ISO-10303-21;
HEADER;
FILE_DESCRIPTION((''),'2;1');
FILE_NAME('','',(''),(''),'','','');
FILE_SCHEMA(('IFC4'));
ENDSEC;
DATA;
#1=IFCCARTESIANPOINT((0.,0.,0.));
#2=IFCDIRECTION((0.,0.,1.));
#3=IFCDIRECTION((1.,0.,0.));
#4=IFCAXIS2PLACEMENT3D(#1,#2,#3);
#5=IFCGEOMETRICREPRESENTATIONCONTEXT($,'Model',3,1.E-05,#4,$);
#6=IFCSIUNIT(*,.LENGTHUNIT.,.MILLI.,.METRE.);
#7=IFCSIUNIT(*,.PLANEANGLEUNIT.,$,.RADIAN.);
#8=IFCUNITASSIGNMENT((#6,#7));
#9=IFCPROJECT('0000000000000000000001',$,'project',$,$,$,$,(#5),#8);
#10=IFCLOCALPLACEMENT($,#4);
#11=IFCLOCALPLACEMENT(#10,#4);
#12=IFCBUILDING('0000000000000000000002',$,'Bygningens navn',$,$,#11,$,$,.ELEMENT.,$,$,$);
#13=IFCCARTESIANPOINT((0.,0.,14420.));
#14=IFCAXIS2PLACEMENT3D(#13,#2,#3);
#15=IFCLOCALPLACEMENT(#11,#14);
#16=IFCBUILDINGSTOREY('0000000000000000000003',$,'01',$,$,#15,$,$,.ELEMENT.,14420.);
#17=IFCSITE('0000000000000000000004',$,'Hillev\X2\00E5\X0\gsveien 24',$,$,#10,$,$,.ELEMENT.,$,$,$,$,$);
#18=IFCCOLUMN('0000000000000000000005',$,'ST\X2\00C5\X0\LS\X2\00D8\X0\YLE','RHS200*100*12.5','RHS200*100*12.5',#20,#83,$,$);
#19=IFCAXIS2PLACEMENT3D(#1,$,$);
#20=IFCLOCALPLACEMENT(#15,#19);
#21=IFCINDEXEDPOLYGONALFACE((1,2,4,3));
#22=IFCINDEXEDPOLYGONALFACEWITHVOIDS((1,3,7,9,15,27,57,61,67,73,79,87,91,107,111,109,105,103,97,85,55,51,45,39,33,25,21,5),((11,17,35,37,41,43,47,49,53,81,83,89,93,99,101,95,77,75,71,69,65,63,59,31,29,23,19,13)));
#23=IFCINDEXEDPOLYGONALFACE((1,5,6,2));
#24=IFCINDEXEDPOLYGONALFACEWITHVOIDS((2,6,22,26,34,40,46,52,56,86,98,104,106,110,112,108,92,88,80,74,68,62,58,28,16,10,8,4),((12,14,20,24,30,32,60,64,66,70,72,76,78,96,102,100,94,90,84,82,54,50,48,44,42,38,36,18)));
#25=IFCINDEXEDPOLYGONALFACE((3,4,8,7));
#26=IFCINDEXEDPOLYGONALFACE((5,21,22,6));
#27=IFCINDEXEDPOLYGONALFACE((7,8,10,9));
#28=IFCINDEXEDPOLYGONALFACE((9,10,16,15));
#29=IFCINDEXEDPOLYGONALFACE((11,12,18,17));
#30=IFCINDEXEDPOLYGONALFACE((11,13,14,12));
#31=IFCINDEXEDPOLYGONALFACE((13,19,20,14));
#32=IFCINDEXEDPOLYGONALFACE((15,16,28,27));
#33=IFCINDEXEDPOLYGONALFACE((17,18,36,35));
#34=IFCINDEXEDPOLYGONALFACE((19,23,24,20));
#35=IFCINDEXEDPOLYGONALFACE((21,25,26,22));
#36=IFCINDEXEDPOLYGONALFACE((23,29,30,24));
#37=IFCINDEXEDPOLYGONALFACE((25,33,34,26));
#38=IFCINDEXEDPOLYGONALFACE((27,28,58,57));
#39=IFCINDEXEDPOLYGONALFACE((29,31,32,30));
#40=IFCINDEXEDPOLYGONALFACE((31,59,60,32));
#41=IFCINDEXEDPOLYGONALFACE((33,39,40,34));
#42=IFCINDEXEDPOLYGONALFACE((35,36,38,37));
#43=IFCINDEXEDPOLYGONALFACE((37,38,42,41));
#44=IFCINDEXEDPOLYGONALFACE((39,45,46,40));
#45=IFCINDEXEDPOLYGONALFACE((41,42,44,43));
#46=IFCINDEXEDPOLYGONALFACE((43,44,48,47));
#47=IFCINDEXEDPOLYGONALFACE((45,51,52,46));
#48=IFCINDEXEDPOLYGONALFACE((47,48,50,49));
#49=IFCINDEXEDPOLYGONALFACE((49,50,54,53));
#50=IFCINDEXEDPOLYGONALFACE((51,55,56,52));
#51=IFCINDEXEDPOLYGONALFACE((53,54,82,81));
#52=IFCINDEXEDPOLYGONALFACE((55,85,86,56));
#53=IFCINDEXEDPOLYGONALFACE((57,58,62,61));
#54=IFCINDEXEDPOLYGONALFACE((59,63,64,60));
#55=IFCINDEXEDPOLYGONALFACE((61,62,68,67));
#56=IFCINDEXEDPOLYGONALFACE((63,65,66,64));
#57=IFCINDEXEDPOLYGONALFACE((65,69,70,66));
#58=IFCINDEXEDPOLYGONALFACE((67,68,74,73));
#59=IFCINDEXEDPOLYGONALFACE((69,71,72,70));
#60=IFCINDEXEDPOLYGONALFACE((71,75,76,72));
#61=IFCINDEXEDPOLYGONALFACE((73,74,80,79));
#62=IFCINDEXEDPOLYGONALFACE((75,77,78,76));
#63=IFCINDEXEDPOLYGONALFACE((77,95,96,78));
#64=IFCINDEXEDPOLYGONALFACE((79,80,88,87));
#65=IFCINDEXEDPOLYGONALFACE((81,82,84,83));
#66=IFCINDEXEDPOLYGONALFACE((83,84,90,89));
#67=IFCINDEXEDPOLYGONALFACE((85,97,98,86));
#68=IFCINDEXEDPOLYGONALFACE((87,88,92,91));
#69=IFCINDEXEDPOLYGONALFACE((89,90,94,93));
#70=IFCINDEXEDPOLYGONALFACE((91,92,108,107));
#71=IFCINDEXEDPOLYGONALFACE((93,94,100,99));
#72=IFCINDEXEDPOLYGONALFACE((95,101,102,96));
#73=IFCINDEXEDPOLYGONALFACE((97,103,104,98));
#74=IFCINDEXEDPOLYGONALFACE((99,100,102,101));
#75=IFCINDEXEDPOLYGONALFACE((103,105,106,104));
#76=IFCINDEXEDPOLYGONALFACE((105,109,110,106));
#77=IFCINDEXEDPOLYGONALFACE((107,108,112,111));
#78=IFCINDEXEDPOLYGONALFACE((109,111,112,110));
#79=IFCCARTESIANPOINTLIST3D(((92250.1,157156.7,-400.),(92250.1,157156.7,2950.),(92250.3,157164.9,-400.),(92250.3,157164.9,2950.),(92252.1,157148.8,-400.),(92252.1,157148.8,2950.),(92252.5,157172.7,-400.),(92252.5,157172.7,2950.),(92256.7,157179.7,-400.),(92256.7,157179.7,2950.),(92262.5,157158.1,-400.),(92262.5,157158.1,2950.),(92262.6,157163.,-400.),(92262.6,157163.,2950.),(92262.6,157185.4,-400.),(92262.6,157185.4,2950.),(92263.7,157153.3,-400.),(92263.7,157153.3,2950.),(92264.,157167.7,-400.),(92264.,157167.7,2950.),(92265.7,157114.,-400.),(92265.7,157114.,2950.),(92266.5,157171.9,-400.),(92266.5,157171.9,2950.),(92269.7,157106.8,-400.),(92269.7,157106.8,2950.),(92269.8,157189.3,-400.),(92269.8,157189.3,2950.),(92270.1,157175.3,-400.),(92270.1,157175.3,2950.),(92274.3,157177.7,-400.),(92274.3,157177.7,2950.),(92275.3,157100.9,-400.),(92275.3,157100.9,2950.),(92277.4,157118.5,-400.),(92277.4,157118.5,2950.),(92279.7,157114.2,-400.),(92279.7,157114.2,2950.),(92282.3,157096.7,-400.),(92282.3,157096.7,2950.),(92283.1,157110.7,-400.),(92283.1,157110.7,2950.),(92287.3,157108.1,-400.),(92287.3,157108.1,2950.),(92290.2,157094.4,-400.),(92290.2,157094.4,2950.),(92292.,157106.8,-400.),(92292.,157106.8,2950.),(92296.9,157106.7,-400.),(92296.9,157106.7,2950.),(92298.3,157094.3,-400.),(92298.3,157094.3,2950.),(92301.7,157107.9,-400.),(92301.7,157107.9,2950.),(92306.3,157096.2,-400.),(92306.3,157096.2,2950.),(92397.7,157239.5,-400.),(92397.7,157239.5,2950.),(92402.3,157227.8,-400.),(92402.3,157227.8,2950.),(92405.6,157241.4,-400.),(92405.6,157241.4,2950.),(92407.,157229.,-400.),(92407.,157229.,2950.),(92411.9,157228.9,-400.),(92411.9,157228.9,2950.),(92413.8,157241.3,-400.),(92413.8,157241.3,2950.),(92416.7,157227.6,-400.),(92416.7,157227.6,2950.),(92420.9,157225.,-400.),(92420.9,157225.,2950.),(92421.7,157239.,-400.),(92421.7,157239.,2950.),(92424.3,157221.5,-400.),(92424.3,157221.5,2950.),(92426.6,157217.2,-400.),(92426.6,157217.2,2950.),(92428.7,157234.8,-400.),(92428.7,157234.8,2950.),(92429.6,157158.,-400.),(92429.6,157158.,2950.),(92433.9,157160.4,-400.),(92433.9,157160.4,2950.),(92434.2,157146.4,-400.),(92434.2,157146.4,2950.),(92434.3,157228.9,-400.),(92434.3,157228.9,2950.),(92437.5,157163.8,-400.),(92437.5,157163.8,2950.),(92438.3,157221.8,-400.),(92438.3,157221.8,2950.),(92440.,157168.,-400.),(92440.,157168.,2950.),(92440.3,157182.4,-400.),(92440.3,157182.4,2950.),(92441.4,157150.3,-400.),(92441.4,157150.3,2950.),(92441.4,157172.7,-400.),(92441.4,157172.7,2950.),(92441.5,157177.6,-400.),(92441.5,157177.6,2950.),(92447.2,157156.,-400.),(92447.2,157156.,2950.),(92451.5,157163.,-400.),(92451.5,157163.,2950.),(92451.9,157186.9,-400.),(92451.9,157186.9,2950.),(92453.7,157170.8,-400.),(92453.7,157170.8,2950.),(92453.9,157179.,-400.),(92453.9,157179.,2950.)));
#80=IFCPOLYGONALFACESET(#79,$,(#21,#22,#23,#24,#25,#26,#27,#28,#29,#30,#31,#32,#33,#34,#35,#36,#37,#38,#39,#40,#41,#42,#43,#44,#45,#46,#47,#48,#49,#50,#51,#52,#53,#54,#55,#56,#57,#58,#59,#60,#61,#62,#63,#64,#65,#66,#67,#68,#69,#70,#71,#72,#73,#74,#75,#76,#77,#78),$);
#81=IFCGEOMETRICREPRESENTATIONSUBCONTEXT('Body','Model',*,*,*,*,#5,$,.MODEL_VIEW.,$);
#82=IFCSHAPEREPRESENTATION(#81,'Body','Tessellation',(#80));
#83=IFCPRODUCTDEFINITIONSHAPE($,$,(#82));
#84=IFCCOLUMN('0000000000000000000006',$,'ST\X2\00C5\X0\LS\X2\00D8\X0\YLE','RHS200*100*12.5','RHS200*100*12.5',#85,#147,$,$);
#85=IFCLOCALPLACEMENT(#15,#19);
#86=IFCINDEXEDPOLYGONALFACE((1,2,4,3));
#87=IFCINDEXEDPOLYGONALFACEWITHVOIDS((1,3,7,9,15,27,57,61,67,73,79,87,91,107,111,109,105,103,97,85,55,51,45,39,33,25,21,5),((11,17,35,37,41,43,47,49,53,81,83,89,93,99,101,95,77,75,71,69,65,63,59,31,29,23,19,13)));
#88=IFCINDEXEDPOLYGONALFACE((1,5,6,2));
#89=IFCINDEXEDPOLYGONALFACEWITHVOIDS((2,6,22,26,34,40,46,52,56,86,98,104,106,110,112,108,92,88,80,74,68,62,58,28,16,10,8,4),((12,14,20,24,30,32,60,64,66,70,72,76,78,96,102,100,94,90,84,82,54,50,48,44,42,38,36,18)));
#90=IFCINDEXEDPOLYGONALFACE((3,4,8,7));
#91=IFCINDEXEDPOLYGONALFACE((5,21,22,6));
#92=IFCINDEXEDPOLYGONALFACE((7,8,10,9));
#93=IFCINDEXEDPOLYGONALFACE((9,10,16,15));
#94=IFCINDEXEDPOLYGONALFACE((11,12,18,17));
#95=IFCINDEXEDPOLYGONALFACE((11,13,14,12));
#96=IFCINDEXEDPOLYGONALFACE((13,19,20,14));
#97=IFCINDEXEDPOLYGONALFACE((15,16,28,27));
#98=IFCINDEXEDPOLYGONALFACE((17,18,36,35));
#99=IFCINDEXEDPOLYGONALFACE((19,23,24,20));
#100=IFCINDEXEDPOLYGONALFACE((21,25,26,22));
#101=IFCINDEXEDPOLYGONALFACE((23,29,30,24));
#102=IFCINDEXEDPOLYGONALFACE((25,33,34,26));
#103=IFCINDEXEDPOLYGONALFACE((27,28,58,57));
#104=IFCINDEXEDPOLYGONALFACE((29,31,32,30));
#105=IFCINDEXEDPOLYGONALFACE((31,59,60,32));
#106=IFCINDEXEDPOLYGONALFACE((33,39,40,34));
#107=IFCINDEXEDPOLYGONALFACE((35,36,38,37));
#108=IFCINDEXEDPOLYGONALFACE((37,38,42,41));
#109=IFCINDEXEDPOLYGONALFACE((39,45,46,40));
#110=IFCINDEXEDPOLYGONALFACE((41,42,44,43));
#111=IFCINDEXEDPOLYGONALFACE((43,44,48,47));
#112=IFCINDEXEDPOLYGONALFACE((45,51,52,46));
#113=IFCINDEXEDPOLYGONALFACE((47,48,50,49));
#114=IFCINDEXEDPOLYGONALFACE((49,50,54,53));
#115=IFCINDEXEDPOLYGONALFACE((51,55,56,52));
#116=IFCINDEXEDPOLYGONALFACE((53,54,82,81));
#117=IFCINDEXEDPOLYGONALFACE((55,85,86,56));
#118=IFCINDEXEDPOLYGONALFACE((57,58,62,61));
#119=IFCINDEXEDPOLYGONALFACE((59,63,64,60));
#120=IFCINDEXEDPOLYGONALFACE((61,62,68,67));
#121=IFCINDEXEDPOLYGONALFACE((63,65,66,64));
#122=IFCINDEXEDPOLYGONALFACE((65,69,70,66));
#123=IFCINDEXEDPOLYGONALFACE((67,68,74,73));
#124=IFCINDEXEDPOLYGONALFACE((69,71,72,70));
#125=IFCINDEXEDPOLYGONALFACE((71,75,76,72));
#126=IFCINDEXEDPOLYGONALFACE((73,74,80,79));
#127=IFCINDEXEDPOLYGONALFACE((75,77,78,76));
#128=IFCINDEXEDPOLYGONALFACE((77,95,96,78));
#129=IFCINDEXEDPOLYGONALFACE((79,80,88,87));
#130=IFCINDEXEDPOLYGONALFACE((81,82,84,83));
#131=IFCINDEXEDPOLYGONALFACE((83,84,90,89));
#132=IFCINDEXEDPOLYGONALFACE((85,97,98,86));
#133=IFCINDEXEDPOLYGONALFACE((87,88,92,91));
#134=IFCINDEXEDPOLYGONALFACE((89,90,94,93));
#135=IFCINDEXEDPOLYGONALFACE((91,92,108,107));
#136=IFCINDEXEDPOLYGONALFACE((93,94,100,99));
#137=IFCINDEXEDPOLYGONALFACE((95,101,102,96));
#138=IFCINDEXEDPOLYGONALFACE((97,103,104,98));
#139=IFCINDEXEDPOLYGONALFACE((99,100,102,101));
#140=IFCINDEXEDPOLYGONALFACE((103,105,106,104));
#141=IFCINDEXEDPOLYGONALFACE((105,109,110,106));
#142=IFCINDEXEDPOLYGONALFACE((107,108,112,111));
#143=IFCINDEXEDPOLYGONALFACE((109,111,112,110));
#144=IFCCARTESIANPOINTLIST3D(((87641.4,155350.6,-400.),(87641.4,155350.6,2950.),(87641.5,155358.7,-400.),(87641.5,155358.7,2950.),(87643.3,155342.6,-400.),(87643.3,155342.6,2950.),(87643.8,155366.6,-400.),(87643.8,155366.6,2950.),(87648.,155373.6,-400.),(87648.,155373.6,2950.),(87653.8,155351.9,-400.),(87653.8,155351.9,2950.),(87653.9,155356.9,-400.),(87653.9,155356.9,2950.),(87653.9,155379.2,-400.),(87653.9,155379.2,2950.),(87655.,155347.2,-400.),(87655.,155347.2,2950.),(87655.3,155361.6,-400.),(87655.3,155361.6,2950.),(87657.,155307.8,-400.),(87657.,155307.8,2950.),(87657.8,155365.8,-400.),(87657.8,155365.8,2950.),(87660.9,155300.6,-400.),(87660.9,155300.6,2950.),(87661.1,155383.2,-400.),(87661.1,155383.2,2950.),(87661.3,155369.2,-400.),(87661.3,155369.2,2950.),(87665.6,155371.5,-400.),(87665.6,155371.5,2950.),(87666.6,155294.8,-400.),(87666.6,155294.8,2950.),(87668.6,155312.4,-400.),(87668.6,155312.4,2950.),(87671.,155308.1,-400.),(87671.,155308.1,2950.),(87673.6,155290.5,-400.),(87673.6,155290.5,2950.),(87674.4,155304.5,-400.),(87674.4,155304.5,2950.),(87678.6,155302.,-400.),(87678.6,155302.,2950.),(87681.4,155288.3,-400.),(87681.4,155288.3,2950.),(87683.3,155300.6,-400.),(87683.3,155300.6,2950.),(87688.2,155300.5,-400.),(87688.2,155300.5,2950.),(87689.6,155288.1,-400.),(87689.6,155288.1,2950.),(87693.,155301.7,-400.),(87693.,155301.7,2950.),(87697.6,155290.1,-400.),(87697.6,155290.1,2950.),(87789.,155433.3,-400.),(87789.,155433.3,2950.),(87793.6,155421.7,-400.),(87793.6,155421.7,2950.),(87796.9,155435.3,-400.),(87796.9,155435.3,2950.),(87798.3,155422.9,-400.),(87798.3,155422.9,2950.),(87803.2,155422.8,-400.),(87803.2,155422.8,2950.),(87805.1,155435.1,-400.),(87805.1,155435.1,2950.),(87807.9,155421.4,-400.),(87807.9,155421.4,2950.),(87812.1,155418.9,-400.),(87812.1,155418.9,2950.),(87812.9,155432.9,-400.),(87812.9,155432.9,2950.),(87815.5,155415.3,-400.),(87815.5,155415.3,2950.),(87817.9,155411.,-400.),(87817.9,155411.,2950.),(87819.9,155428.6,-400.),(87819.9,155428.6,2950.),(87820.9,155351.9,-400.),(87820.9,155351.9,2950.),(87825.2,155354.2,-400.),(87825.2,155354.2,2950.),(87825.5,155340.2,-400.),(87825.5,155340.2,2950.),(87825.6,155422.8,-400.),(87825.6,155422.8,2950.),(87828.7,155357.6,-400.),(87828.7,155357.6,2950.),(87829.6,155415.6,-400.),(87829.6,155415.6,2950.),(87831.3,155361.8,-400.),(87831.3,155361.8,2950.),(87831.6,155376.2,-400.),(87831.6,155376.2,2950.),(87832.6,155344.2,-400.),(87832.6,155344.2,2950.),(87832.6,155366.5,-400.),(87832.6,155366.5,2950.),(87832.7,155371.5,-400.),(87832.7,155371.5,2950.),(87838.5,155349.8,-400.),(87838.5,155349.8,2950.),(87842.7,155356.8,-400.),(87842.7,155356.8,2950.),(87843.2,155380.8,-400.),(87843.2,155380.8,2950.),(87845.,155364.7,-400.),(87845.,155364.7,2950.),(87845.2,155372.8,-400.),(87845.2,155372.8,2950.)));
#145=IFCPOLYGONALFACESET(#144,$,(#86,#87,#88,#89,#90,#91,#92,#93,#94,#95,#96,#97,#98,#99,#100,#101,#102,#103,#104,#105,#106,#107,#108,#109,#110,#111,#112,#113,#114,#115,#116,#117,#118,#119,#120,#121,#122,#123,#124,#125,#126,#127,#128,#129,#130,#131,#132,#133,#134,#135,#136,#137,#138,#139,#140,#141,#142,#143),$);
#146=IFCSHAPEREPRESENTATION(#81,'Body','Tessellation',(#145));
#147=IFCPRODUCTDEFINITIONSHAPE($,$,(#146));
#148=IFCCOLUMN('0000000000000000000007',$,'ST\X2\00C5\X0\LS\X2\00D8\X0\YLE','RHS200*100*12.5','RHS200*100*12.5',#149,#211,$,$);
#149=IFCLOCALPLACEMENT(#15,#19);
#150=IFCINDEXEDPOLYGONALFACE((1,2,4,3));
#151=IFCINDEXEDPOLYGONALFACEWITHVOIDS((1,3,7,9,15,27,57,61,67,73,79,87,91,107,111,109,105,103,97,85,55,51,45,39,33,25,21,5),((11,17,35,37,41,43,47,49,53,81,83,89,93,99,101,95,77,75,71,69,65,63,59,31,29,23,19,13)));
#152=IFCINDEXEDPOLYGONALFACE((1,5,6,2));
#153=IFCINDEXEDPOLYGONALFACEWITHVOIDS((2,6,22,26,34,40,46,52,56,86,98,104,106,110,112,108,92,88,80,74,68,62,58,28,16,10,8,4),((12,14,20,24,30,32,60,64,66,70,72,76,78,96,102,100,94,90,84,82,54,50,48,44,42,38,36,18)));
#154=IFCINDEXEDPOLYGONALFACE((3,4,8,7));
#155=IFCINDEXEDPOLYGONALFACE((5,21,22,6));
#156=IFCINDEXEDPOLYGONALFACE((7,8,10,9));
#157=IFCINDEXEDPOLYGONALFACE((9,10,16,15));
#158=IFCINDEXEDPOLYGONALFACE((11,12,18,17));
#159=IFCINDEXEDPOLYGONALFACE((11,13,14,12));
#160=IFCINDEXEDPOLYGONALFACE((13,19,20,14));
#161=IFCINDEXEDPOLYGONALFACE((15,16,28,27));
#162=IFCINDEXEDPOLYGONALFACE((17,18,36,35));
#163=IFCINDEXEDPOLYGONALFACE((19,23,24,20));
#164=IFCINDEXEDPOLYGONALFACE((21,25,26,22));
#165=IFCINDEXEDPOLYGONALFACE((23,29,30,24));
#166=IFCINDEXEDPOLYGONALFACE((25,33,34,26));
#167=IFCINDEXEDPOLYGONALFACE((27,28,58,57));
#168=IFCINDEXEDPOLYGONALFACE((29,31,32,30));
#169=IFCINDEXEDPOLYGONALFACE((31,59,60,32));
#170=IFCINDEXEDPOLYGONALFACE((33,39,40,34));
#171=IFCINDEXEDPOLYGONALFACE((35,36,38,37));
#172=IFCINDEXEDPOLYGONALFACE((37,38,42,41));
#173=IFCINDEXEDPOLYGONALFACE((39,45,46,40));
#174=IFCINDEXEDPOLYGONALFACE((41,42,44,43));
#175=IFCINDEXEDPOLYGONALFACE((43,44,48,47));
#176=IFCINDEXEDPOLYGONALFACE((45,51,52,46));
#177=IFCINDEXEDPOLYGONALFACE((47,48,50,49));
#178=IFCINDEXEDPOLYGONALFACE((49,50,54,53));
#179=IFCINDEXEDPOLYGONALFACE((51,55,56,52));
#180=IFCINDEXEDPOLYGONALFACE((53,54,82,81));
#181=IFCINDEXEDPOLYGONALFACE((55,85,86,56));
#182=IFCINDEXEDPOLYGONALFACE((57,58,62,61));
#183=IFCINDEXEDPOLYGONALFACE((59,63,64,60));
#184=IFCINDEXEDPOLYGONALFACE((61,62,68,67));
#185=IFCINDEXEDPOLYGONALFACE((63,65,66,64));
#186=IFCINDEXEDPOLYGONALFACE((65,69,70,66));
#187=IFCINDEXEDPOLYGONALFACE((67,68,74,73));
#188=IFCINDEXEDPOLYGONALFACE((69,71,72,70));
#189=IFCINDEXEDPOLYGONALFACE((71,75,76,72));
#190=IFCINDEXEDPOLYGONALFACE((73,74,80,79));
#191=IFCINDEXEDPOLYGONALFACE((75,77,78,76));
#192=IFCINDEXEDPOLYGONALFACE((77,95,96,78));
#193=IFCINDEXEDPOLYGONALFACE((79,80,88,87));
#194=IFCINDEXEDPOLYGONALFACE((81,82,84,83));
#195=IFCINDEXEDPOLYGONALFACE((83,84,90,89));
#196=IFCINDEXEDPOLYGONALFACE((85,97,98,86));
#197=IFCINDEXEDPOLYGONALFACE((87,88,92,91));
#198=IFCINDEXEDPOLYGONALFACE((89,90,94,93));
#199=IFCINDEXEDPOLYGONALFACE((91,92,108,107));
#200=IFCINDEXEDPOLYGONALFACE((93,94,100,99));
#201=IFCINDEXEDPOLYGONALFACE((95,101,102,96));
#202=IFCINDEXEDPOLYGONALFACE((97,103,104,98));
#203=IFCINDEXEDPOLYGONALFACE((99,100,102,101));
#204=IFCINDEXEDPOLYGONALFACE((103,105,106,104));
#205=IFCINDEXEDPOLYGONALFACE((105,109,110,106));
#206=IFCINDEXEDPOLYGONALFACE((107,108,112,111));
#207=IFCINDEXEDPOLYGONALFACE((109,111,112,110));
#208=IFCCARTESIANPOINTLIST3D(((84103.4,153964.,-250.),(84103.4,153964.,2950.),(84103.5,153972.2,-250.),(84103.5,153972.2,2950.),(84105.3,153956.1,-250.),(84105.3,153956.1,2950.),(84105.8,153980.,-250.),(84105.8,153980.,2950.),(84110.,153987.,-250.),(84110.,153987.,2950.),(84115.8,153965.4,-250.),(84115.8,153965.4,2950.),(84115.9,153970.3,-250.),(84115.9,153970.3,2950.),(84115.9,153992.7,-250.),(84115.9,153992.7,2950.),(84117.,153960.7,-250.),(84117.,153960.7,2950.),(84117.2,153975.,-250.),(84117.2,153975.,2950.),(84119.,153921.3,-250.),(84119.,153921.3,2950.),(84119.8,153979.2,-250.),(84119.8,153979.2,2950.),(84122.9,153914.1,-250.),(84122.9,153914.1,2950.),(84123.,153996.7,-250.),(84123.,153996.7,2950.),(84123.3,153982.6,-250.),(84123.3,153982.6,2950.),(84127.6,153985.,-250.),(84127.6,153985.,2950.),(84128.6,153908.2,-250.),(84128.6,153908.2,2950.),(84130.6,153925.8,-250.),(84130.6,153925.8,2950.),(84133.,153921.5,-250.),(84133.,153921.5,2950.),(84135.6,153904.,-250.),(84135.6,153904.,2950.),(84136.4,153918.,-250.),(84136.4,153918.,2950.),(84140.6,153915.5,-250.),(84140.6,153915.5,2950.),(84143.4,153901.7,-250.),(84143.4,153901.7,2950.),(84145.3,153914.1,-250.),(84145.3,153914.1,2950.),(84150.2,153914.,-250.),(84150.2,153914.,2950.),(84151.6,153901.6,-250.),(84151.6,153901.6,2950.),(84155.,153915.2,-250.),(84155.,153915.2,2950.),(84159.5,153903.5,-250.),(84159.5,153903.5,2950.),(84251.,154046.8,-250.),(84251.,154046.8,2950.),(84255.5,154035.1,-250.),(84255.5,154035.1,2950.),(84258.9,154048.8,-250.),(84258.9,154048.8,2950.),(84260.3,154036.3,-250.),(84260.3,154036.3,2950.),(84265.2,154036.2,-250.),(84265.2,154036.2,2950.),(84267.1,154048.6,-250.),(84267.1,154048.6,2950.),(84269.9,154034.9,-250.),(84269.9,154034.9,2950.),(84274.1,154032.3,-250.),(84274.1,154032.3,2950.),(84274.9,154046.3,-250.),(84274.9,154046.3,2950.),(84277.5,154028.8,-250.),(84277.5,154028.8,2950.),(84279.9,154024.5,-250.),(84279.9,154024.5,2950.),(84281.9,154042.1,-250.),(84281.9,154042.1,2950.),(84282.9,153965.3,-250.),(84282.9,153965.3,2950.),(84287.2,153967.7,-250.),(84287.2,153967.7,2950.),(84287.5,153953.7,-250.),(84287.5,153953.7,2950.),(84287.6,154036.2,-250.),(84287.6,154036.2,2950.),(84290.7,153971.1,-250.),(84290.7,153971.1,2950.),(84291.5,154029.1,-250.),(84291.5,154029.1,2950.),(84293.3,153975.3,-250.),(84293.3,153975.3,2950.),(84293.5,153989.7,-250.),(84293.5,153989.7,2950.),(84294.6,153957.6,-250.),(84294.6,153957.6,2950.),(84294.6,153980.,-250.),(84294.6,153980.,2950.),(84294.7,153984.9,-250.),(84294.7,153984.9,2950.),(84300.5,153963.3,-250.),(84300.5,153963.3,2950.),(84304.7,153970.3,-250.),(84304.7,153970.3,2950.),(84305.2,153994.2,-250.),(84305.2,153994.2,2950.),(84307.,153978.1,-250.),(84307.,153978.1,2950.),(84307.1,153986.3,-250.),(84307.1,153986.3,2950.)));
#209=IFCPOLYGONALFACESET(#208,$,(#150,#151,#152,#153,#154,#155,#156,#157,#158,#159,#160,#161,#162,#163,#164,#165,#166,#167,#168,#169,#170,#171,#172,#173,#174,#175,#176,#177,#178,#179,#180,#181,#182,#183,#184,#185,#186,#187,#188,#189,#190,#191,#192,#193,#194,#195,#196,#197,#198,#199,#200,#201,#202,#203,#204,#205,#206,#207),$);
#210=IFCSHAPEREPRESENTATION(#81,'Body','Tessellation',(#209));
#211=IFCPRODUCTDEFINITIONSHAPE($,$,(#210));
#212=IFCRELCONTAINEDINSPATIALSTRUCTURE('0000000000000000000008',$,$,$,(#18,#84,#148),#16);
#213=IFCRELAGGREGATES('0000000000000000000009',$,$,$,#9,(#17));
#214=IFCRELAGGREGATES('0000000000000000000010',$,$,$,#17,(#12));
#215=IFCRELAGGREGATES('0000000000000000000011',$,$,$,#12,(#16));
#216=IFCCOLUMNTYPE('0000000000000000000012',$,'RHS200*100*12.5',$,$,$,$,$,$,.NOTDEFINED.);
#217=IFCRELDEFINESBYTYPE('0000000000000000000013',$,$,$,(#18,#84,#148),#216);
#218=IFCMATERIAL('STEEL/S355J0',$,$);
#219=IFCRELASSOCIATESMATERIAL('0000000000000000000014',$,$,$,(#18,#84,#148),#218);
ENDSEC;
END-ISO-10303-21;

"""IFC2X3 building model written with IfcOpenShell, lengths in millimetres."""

from ifc_helpers import new_model, si_unit, frame, frame_2d, origin_with_axes, place, context, subcontext, project, spatial, hollow_rectangle, extrude, material, type_object, element, save


model = new_model("IFC2X3")

# Units and contexts
model_context = context("Model", 3, precision=1e-05, world=origin_with_axes())
body_context = subcontext(model_context, "Body", "Model", "MODEL_VIEW")
ifc_project = project(units=[si_unit("LENGTHUNIT", "METRE", prefix="MILLI"), si_unit("PLANEANGLEUNIT", "RADIAN")], contexts=[model_context])

# Site, building, storey
site_placement = place(None, origin_with_axes())
site = spatial("IfcSite", under=ifc_project, at=site_placement, Name="Hillevågsveien 24", CompositionType="ELEMENT")
building_placement = place(site_placement, origin_with_axes())
building = spatial("IfcBuilding", under=site, at=building_placement, Name="Bygningens navn", CompositionType="ELEMENT")
storey_placement = place(building_placement, frame((0.0, 0.0, 14420.0), z_axis=(0.0, 0.0, 1.0), x_axis=(1.0, 0.0, 0.0)))
storey = spatial("IfcBuildingStorey", under=building, at=storey_placement, Name="01", CompositionType="ELEMENT", Elevation=14420.0)

# Columns
ifc_material_1 = material(Name="STEEL/S355J0")
column_type = type_object("IfcColumnType", Name="RHS200*100*12.5", PredefinedType="NOTDEFINED")
for number, where, z_axis, x_axis, name in (
    (1, (92352.0, 157167.9, -400.0), (0.0, 0.0, 1.0), (0.931056, 0.364877, 0.0), "STÅLSØYLE"),
    (2, (87743.3, 155361.7, -400.0), (0.0, 0.0, 1.0), (0.931056, 0.364877, 0.0), "STÅLSØYLE"),
):
    element("IfcColumn", number, at=place(storey_placement, frame(where, z_axis=z_axis, x_axis=x_axis)), inside=storey, type_object=column_type, material=ifc_material_1, Name=name, Description="RHS200*100*12.5", ObjectType="RHS200*100*12.5", context=body_context, shape_type="SweptSolid", body=[
        extrude(hollow_rectangle(XDim=100.0, YDim=200.0, WallThickness=12.5, InnerFilletRadius=18.8, OuterFilletRadius=31.3, at=frame_2d((0.0, 0.0), x_axis=(1.0, 0.0))), frame((0.0, 0.0, 3350.0), z_axis=(0.0, 0.0, -1.0), x_axis=(0.0, 1.0, 0.0)), (0.0, 0.0, 1.0), 3350.0),
    ])
column_1_placement = place(storey_placement, frame((84205.3, 153975.2, -250.0), z_axis=(0.0, 0.0, 1.0), x_axis=(0.931056, 0.364877, 0.0)))
element("IfcColumn", 3, at=column_1_placement, inside=storey, type_object=column_type, material=ifc_material_1, Name="STÅLSØYLE", Description="RHS200*100*12.5", ObjectType="RHS200*100*12.5", context=body_context, shape_type="SweptSolid", body=[
    extrude(hollow_rectangle(XDim=100.0, YDim=200.0, WallThickness=12.5, InnerFilletRadius=18.8, OuterFilletRadius=31.3, at=frame_2d((0.0, 0.0), x_axis=(1.0, 0.0))), frame((0.0, 0.0, 3200.0), z_axis=(0.0, 0.0, -1.0), x_axis=(0.0, 1.0, 0.0)), (0.0, 0.0, 1.0), 3200.0),
])

save(model, "model.ifc")
